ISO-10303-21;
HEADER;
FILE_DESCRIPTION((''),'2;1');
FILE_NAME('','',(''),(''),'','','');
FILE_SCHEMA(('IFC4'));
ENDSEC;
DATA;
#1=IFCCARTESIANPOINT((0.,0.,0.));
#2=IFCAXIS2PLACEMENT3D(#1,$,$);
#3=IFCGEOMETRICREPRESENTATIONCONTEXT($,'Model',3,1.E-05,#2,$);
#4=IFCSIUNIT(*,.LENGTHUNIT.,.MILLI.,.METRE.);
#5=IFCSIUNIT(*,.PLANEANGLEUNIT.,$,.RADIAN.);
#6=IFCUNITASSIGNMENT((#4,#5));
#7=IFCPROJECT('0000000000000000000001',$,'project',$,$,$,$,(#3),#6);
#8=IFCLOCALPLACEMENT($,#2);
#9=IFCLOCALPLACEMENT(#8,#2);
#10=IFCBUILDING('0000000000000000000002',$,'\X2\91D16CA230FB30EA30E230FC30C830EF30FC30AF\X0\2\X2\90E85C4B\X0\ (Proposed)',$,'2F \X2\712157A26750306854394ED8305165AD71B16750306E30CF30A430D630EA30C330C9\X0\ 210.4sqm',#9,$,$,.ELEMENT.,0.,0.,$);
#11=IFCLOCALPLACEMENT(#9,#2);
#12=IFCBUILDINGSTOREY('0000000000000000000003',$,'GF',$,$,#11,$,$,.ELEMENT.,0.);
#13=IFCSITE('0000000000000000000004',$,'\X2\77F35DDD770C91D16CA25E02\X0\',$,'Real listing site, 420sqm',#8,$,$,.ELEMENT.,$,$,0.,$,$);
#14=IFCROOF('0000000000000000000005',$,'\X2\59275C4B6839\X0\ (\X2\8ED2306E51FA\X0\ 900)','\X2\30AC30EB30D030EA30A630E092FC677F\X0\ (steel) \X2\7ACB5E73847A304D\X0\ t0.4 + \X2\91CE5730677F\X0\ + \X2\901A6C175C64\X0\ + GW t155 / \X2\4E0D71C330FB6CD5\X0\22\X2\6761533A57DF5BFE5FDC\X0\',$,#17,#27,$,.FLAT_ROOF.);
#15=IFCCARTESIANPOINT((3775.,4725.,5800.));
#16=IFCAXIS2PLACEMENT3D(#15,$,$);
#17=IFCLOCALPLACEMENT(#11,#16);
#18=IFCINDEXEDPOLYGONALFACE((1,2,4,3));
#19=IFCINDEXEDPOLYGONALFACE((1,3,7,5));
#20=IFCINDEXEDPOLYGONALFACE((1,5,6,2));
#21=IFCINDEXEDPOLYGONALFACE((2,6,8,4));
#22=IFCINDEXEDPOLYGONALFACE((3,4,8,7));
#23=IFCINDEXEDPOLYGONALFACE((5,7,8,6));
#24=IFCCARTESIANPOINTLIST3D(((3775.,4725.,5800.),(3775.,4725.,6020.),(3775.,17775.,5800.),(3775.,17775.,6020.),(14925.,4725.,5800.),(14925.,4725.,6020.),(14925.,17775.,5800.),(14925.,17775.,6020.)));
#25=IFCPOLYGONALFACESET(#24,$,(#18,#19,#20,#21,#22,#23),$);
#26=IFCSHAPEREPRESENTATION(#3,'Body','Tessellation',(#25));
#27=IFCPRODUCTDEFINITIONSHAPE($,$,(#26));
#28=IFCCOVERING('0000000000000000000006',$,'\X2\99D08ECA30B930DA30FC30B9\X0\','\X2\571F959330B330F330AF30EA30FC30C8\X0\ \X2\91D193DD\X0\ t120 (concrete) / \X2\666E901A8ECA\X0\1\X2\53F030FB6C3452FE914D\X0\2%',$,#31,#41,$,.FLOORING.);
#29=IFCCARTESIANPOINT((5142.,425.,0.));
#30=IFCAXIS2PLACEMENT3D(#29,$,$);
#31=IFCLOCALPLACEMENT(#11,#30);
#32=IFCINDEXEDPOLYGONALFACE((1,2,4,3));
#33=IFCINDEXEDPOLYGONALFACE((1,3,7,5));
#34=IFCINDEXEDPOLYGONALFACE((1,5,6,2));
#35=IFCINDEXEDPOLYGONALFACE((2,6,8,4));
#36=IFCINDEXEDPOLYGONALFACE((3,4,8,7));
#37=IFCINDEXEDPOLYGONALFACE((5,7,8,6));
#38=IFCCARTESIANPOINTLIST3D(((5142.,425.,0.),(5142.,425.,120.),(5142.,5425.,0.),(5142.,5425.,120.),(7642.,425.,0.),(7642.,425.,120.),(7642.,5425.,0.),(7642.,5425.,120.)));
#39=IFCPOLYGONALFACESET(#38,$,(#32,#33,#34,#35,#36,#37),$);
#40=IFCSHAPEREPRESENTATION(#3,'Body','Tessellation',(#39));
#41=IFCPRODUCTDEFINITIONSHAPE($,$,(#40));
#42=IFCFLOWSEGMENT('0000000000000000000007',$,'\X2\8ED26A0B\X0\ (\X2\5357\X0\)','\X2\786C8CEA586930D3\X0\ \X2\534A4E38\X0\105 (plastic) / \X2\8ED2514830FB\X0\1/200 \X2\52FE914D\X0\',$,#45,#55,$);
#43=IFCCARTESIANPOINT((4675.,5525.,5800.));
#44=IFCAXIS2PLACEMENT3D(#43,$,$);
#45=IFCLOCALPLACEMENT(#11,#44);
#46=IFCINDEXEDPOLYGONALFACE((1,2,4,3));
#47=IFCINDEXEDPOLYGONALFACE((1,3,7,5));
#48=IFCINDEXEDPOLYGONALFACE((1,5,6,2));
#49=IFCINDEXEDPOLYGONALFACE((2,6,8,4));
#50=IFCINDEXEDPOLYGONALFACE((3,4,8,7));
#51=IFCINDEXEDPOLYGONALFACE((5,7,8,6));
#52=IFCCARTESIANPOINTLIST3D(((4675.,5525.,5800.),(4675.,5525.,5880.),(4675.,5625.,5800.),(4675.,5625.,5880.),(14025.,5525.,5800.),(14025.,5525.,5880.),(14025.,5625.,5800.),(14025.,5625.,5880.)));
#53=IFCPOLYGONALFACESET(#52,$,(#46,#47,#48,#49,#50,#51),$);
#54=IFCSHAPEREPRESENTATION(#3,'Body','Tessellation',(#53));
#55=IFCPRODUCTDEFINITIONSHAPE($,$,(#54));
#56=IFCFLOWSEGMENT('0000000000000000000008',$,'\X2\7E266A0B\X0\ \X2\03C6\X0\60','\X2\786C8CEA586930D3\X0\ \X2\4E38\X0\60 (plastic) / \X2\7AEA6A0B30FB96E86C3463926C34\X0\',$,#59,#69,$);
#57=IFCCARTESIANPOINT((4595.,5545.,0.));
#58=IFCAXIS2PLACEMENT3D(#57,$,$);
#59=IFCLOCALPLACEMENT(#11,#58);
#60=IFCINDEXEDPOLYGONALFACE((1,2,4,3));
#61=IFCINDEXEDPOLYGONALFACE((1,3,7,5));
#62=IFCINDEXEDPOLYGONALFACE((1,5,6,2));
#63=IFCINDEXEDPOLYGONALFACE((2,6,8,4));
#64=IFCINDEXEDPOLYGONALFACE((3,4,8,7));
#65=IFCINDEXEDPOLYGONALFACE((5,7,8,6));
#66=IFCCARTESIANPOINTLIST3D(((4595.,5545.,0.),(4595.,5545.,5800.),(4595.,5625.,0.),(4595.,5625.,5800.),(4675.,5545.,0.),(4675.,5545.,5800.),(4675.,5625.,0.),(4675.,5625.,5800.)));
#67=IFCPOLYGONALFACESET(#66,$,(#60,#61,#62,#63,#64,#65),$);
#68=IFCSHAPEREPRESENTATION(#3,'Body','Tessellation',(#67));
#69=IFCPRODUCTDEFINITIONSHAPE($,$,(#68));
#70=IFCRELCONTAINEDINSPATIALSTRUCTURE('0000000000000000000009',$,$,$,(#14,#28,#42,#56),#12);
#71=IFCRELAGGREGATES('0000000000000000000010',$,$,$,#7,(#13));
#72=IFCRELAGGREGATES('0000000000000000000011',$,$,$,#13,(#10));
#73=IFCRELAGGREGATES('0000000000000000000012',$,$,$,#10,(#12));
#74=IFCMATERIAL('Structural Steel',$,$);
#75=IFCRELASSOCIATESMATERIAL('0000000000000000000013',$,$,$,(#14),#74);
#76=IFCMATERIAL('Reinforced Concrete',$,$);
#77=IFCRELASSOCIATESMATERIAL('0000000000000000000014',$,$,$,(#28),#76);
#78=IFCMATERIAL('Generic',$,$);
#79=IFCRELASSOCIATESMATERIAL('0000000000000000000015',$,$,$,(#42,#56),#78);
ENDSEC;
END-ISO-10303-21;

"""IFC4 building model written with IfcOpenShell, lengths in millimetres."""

from ifc_helpers import new_model, si_unit, frame, frame_2d, origin, place, context, project, spatial, rectangle, extrude, material, element, save


model = new_model("IFC4")

# Units and contexts
model_context = context("Model", 3, precision=1e-05, world=origin())
ifc_project = project(units=[si_unit("LENGTHUNIT", "METRE", prefix="MILLI"), si_unit("PLANEANGLEUNIT", "RADIAN")], contexts=[model_context])

# Site, building, storey
site_placement = place(None, origin())
site = spatial("IfcSite", under=ifc_project, at=site_placement, Name="石川県金沢市", ObjectType="Real listing site, 420sqm", CompositionType="ELEMENT", RefElevation=0.0)
building_placement = place(site_placement, origin())
building = spatial("IfcBuilding", under=site, at=building_placement, Name="金沢・リモートワーク2部屋 (Proposed)", ObjectType="2F 無垢材と吹付け断熱材のハイブリッド 210.4sqm", CompositionType="ELEMENT", ElevationOfRefHeight=0.0, ElevationOfTerrain=0.0)
storey_placement = place(building_placement, origin())
storey = spatial("IfcBuildingStorey", under=building, at=storey_placement, Name="GF", CompositionType="ELEMENT", Elevation=0.0)

# Shared definitions
ifc_material_1 = material(Name="Reinforced Concrete")

# Roof
ifc_material_2 = material(Name="Structural Steel")
roof_placement = place(storey_placement, frame((3775.0, 4725.0, 5800.0)))
element("IfcRoof", 1, at=roof_placement, inside=storey, material=ifc_material_2, Name="大屋根 (軒の出 900)", Description="ガルバリウム鋼板 (steel) 立平葺き t0.4 + 野地板 + 通気層 + GW t155 / 不燃・法22条区域対応", PredefinedType="FLAT_ROOF", context=model_context, shape_type="SweptSolid", body=[
    extrude(rectangle(XDim=11150.0, YDim=13050.0, at=frame_2d((5575.0, 6525.0))), frame((3775.0, 4725.0, 5800.0)), (0.0, 0.0, 1.0), 220.0),
])

# Covering
covering_placement = place(storey_placement, frame((5142.0, 425.0, 0.0)))
element("IfcCovering", 2, at=covering_placement, inside=storey, material=ifc_material_1, Name="駐車スペース", Description="土間コンクリート 金鏝 t120 (concrete) / 普通車1台・水勾配2%", PredefinedType="FLOORING", context=model_context, shape_type="SweptSolid", body=[
    extrude(rectangle(XDim=2500.0, YDim=5000.0, at=frame_2d((1250.0, 2500.0))), frame((5142.0, 425.0, 0.0)), (0.0, 0.0, 1.0), 120.0),
])

# Flow segments
ifc_material_3 = material(Name="Generic")
flow_segment_1_placement = place(storey_placement, frame((4675.0, 5525.0, 5800.0)))
element("IfcFlowSegment", 3, at=flow_segment_1_placement, inside=storey, material=ifc_material_3, Name="軒樋 (南)", Description="硬質塩ビ 半丸105 (plastic) / 軒先・1/200 勾配", context=model_context, shape_type="SweptSolid", body=[
    extrude(rectangle(XDim=9350.0, YDim=100.0, at=frame_2d((4675.0, 50.0))), frame((4675.0, 5525.0, 5800.0)), (0.0, 0.0, 1.0), 80.0),
])
flow_segment_2_placement = place(storey_placement, frame((4595.0, 5545.0, 0.0)))
element("IfcFlowSegment", 4, at=flow_segment_2_placement, inside=storey, material=ifc_material_3, Name="縦樋 φ60", Description="硬質塩ビ 丸60 (plastic) / 竪樋・雨水排水", context=model_context, shape_type="SweptSolid", body=[
    extrude(rectangle(XDim=80.0, YDim=80.0, at=frame_2d((40.0, 40.0))), frame((4595.0, 5545.0, 0.0)), (0.0, 0.0, 1.0), 5800.0),
])

save(model, "model.ifc")
